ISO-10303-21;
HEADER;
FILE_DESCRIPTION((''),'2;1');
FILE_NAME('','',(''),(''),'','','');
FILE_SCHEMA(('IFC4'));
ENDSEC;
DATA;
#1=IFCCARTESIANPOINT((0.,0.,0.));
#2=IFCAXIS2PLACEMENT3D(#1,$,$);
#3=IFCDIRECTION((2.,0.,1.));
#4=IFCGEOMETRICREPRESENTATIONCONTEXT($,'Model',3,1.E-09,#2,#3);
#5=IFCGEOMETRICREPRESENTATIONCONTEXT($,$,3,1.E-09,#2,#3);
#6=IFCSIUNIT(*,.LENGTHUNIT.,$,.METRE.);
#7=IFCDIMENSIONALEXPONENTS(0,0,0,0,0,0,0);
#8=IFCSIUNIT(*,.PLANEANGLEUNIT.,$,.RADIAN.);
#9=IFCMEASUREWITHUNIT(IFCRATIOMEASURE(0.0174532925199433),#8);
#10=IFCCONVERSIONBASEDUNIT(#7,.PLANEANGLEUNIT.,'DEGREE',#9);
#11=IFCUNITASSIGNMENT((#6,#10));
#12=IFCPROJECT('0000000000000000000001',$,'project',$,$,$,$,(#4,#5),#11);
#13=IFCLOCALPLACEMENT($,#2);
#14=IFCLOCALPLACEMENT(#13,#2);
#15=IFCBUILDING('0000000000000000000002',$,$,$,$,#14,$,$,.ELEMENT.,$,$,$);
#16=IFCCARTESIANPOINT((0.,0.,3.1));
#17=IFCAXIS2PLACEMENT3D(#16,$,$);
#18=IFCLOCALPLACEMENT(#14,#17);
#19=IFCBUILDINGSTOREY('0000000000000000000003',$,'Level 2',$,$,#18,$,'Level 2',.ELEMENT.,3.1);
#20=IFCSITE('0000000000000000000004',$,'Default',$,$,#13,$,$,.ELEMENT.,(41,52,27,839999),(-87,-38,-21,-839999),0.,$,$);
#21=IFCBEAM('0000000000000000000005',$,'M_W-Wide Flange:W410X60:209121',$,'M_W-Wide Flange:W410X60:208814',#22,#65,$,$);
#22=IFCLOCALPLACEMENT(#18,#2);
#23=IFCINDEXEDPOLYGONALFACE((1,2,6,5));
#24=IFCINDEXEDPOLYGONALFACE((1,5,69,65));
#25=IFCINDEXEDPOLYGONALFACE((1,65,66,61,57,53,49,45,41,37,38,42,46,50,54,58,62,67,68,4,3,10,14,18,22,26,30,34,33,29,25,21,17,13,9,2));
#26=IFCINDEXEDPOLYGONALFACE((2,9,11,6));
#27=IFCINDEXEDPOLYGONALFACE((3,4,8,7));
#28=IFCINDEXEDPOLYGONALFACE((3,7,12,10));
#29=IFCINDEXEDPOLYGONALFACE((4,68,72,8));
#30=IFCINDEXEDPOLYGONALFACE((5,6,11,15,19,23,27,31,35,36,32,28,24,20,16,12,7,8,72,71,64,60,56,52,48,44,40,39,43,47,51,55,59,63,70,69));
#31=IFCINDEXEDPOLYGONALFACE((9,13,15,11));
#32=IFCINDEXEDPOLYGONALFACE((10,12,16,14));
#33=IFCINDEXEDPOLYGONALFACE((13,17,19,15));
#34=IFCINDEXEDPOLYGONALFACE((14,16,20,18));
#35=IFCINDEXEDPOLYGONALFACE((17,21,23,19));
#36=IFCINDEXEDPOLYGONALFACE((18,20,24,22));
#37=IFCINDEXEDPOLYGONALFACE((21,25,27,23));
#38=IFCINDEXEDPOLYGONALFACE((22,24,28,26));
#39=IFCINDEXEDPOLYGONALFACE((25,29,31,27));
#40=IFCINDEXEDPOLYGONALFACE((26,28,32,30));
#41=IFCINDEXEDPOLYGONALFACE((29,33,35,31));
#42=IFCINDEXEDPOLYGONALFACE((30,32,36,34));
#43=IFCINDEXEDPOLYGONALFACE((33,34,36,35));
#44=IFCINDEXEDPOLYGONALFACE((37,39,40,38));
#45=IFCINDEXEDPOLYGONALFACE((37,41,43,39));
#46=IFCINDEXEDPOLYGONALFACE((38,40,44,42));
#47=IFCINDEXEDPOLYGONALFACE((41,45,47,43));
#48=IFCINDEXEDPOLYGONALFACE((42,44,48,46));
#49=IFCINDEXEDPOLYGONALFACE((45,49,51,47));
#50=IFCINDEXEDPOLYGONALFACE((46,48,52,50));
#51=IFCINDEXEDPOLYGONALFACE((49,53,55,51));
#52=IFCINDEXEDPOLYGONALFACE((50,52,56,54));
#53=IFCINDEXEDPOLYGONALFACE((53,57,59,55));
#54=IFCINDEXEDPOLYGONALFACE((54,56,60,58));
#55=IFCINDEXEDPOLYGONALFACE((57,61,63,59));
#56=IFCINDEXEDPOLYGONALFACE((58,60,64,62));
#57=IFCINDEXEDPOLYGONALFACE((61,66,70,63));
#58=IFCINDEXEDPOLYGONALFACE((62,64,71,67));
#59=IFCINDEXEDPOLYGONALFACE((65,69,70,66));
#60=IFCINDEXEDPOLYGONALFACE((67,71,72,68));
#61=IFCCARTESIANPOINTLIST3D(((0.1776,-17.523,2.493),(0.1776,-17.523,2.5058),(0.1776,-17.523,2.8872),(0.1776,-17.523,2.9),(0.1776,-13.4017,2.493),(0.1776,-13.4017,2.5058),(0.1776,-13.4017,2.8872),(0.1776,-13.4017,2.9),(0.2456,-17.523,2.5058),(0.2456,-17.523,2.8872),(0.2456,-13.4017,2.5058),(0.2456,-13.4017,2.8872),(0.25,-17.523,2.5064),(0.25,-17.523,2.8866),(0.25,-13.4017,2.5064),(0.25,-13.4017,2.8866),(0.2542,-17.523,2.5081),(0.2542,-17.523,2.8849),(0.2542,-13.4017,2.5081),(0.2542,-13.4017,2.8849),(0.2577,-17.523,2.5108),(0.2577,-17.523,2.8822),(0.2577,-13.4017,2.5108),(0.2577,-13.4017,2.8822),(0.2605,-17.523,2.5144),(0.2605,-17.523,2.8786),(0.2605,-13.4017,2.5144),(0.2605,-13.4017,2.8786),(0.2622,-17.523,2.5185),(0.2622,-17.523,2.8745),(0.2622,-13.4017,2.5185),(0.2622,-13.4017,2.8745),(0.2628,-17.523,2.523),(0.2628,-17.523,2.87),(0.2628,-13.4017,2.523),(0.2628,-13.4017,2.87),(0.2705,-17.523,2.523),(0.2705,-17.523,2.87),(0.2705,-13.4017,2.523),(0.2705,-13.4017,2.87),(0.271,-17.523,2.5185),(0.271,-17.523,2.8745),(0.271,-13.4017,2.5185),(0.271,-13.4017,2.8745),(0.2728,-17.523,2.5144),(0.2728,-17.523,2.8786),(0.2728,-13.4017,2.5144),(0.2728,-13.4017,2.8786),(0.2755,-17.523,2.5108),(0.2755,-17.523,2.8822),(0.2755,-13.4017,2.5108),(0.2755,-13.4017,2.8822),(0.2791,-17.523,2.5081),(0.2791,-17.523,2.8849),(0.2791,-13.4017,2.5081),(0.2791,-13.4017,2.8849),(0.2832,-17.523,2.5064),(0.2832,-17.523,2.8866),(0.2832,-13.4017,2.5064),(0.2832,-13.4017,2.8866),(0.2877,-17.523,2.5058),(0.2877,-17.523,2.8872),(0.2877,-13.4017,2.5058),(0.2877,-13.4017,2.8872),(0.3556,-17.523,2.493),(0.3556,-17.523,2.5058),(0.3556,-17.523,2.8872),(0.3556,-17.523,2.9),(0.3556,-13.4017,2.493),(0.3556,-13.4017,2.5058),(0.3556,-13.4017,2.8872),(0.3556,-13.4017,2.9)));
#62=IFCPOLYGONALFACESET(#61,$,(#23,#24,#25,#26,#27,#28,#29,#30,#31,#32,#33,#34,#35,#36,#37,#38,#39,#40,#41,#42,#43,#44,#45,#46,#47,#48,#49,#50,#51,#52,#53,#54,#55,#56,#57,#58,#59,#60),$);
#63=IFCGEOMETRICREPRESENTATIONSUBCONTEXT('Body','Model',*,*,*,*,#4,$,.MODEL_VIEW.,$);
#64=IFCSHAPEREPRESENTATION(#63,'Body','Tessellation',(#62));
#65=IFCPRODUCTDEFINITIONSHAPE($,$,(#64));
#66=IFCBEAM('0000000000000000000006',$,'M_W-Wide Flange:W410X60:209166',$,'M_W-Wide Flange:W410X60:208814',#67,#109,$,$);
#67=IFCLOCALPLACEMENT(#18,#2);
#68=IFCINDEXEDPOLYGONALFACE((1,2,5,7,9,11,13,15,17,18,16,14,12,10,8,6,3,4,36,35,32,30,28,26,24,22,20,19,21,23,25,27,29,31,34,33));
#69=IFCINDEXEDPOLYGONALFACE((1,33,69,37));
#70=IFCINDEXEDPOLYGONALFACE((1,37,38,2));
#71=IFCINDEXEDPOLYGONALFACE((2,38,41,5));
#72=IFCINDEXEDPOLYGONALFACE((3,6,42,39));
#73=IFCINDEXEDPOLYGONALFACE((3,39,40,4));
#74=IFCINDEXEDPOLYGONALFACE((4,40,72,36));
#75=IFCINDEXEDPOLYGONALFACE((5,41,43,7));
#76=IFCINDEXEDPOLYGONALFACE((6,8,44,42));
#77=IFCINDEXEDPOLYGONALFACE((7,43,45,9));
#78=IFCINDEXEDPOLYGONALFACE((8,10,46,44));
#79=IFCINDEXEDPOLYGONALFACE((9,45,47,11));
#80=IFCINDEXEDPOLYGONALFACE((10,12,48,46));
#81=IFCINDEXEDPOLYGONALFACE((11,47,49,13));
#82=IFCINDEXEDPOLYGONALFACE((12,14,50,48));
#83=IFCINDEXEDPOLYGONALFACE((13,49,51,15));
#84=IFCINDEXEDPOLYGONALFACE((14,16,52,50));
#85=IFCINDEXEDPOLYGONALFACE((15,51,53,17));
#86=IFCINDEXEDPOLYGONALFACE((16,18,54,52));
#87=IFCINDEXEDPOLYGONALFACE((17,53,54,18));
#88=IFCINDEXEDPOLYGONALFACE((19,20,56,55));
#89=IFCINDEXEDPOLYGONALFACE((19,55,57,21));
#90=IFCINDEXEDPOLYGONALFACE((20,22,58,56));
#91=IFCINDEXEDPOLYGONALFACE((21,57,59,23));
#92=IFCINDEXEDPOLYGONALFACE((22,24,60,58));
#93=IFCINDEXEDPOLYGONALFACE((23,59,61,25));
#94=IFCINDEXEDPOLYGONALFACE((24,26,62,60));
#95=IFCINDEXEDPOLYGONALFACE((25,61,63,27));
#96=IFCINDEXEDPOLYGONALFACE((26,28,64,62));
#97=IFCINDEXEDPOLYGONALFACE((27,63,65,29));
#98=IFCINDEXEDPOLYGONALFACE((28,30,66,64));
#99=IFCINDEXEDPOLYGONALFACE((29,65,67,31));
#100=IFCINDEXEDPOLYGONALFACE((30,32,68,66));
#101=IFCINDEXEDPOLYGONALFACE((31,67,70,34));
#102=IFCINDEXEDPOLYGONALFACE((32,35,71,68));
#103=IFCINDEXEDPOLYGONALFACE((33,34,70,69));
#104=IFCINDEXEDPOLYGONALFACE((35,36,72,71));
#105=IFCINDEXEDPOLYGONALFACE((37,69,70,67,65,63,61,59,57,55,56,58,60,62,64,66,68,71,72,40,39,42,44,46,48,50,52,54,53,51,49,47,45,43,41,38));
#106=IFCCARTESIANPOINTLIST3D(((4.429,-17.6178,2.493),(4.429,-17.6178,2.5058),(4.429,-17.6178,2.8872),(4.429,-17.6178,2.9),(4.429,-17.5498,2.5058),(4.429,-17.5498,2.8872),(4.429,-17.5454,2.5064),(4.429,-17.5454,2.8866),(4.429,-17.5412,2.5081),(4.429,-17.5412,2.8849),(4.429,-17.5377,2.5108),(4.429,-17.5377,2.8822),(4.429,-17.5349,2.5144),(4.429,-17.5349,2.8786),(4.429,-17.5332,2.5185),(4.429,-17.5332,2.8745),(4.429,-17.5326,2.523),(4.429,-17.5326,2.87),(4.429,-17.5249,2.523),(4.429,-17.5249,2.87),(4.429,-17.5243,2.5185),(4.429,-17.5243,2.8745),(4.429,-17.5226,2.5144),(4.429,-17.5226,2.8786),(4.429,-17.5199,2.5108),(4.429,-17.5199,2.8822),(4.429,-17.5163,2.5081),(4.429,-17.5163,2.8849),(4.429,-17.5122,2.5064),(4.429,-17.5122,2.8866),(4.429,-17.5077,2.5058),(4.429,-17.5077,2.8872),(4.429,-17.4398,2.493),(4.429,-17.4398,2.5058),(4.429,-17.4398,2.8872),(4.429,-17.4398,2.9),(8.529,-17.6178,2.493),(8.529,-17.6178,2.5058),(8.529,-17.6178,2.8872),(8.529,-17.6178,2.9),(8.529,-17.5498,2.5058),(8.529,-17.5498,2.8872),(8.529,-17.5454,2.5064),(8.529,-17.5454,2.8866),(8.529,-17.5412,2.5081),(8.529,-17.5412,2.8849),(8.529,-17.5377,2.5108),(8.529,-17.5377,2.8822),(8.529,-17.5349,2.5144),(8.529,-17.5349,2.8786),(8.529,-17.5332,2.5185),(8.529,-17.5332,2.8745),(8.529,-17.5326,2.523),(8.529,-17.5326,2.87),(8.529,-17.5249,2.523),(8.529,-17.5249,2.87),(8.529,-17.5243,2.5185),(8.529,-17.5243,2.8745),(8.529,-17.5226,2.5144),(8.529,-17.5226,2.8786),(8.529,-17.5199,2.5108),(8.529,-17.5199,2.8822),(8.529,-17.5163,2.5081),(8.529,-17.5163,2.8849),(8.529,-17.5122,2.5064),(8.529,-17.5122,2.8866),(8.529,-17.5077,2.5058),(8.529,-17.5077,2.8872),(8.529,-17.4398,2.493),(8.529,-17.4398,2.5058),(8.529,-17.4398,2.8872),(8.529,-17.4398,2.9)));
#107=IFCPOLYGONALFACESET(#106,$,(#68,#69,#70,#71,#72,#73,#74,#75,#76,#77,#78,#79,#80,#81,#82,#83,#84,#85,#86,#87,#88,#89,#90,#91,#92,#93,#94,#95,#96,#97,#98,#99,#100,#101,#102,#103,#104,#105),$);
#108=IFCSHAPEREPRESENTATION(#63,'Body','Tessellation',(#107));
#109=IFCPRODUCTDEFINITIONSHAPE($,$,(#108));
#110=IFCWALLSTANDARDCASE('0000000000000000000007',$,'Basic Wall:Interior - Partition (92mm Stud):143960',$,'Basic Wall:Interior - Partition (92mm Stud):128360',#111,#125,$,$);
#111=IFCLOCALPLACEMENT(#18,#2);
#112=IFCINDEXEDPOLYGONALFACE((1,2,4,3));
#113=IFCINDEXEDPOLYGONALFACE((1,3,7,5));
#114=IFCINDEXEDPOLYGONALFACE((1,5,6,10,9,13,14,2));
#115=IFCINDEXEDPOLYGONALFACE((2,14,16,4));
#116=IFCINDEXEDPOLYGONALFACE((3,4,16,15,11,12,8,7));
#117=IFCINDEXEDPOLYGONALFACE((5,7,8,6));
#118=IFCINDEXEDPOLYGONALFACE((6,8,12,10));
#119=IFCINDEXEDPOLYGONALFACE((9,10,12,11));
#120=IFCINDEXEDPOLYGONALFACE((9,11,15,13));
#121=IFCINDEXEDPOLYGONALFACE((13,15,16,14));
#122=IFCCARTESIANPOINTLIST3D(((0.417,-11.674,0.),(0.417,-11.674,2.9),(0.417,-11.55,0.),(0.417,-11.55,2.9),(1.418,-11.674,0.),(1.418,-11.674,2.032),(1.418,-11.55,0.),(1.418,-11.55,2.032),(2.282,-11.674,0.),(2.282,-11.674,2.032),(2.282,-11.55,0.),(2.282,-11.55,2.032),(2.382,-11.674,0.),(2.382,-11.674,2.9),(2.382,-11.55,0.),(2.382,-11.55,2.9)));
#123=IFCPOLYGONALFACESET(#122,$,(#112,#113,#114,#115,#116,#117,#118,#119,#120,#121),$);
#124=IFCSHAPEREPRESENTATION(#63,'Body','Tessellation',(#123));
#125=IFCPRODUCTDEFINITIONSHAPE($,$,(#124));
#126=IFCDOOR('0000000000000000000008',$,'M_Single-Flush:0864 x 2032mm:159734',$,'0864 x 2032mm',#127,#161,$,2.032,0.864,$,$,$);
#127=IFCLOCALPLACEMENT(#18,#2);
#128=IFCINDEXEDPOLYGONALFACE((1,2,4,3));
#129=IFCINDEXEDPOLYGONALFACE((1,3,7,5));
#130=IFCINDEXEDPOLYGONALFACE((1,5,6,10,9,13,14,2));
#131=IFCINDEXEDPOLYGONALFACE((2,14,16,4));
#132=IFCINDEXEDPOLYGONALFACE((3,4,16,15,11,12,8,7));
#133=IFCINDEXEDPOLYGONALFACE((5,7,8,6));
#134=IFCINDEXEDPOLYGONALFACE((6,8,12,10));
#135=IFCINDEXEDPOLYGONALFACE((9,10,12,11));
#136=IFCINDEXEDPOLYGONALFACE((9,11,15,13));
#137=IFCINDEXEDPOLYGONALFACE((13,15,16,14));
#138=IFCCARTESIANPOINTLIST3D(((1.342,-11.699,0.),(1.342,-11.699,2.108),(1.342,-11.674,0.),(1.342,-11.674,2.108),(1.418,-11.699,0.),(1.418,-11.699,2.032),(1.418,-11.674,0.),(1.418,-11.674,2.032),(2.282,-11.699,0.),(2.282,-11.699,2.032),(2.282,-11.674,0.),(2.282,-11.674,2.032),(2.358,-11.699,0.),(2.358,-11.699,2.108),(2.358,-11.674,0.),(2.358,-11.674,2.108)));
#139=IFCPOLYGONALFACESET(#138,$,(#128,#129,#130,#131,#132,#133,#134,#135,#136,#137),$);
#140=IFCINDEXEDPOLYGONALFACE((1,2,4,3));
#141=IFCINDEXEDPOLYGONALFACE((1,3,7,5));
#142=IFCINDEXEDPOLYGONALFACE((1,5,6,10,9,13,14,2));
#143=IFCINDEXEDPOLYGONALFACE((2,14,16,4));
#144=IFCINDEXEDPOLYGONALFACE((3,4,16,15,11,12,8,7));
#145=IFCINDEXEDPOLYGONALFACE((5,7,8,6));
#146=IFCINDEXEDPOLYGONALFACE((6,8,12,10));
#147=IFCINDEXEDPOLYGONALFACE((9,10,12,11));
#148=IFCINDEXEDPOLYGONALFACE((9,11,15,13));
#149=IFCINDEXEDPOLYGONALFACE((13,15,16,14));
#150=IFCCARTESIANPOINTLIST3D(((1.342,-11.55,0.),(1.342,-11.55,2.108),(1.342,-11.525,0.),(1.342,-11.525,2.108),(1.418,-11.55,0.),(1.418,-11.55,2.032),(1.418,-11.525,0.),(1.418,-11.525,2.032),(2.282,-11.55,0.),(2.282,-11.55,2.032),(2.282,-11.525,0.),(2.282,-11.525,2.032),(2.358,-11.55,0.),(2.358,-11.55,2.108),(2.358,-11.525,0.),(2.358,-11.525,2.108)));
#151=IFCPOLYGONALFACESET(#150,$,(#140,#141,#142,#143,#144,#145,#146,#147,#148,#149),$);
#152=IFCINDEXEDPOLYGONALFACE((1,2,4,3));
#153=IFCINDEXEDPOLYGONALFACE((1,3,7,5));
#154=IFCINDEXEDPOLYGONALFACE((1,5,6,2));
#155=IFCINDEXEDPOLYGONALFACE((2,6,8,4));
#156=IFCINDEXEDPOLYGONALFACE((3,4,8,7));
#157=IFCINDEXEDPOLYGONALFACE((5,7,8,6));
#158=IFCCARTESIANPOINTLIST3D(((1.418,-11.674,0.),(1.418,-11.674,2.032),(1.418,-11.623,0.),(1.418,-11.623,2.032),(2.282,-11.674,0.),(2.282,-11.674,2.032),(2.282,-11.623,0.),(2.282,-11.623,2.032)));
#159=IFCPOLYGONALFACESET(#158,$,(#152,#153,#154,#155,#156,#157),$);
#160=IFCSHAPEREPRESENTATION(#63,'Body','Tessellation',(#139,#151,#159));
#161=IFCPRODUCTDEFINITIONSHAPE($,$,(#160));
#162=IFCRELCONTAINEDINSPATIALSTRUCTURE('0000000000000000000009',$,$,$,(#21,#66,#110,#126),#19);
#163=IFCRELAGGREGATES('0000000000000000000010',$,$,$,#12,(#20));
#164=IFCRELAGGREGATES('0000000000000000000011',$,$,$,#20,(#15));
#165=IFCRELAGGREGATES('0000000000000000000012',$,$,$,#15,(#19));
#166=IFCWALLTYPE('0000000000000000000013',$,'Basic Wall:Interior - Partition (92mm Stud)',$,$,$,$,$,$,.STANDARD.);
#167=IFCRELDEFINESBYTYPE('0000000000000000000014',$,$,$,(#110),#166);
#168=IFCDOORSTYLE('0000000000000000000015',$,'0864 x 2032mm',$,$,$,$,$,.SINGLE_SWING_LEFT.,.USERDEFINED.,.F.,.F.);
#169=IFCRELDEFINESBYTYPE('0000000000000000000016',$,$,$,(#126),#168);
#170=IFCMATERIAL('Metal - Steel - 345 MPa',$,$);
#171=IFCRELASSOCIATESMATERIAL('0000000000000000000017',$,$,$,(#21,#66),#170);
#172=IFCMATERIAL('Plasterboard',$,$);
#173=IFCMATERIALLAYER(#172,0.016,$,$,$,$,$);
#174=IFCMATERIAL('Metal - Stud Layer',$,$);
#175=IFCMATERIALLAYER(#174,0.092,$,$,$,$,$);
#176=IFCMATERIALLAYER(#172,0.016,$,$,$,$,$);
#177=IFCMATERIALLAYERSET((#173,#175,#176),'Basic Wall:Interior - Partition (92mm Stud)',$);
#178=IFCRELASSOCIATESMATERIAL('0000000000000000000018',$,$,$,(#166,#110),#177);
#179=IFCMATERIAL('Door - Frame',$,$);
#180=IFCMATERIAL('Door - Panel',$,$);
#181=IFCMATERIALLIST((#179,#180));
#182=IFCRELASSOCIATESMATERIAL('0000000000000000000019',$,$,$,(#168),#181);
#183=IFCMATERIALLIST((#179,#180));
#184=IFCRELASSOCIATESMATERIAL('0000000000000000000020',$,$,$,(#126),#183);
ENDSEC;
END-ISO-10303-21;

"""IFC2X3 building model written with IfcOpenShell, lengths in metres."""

from ifc_helpers import new_model, entity, si_unit, converted_unit, direction, frame, frame_2d, origin, place, context, subcontext, project, spatial, polyline, rectangle, i_section, outline, extrude, source, transform, mapped, material, material_list, layer, layer_set, layer_usage, type_object, type_shapes, element, fill, save


model = new_model("IFC2X3")

# Units and contexts
model_context = context("Model", 3, precision=1e-09, world=origin(), true_north=direction((2.0, 0.0, 1.0)))
context_of_model = context(None, 3, precision=1e-09, world=origin(), true_north=direction((2.0, 0.0, 1.0)))
body_context = subcontext(model_context, "Body", "Model", "MODEL_VIEW")
ifc_project = project(units=[si_unit("LENGTHUNIT", "METRE"), converted_unit("PLANEANGLEUNIT", "DEGREE", entity("IfcRatioMeasure", 0.0174532925199433), si_unit("PLANEANGLEUNIT", "RADIAN"), dimensions=[0, 0, 0, 0, 0, 0, 0])], contexts=[model_context, context_of_model])

# Site, building, storey
site_placement = place(None, origin())
site = spatial("IfcSite", under=ifc_project, at=site_placement, Name="Default", CompositionType="ELEMENT", RefLatitude=(41, 52, 27, 839999), RefLongitude=(-87, -38, -21, -839999), RefElevation=0.0)
building_placement = place(site_placement, origin())
building = spatial("IfcBuilding", under=site, at=building_placement, CompositionType="ELEMENT")
storey_placement = place(building_placement, frame((0.0, 0.0, 3.1)))
storey = spatial("IfcBuildingStorey", under=building, at=storey_placement, Name="Level 2", LongName="Level 2", CompositionType="ELEMENT", Elevation=3.1)

# Beams
ifc_material_1 = material(Name="Metal - Steel - 345 MPa")
beam_1_placement = place(storey_placement, frame((0.2666, -13.4017, 2.9), z_axis=(0.0, 0.0, 1.0), x_axis=(0.0, -1.0, 0.0)))
element("IfcBeam", 1, at=beam_1_placement, inside=storey, material=ifc_material_1, Name="M_W-Wide Flange:W410X60:209121", ObjectType="M_W-Wide Flange:W410X60:208814", context=body_context, shape_type="SweptSolid", body=[
    extrude(i_section(OverallWidth=0.178, OverallDepth=0.407, WebThickness=0.0077, FlangeThickness=0.0128, FilletRadius=0.0172, at=frame_2d((0.0, 0.0), x_axis=(0.0, 1.0))), frame((0.0, 0.0, -0.2035), z_axis=(1.0, 0.0, 0.0), x_axis=(0.0, 0.0, -1.0)), (0.0, 0.0, 1.0), 4.1213),
])
beam_2_placement = place(storey_placement, frame((4.429, -17.5288, 2.9)))
element("IfcBeam", 2, at=beam_2_placement, inside=storey, material=ifc_material_1, Name="M_W-Wide Flange:W410X60:209166", ObjectType="M_W-Wide Flange:W410X60:208814", context=body_context, shape_type="SweptSolid", body=[
    extrude(i_section(OverallWidth=0.178, OverallDepth=0.407, WebThickness=0.0077, FlangeThickness=0.0128, FilletRadius=0.0172, at=frame_2d((0.0, 0.0), x_axis=(0.0, 1.0))), frame((0.0, 0.0, -0.2035), z_axis=(1.0, 0.0, 0.0), x_axis=(0.0, 0.0, -1.0)), (0.0, 0.0, 1.0), 4.1),
])

# Shared definitions
ifc_material_2 = material(Name="Metal - Stud Layer")
ifc_material_3 = material(Name="Plasterboard")

# Wall, opening, door
ifc_layer_1 = layer(ifc_material_3, 0.016)
ifc_layer_2 = layer(ifc_material_2, 0.092)
ifc_layer_3 = layer(ifc_material_3, 0.016)
ifc_layer_set_1 = layer_set([ifc_layer_1, ifc_layer_2, ifc_layer_3], Name="Basic Wall:Interior - Partition (92mm Stud)")
ifc_layer_usage_1 = layer_usage(ifc_layer_set_1, "AXIS2", "NEGATIVE", 0.062)
wall_type_1 = type_object("IfcWallType", Name="Basic Wall:Interior - Partition (92mm Stud)", PredefinedType="STANDARD", material=ifc_layer_set_1)
wall_1_placement = place(storey_placement, frame((2.382, -11.612, 0.0), z_axis=(0.0, 0.0, 1.0), x_axis=(-1.0, 0.0, 0.0)))
wall_1 = element("IfcWallStandardCase", 3, at=wall_1_placement, inside=storey, type_object=wall_type_1, material=ifc_layer_usage_1, Name="Basic Wall:Interior - Partition (92mm Stud):143960", ObjectType="Basic Wall:Interior - Partition (92mm Stud):128360", context=body_context, shape_type="SweptSolid", body=[
    extrude(rectangle(XDim=1.965, YDim=0.124, at=frame_2d((0.9825, 0.0), x_axis=(-1.0, 0.0))), origin(), (0.0, 0.0, 1.0), 2.9),
])
opening_1_placement = place(wall_1_placement, frame((0.1, -0.062, 0.0)))
opening_1 = element("IfcOpeningElement", 4, at=opening_1_placement, cuts=wall_1, ObjectType="Opening", context=body_context, shape_type="SweptSolid", body=[
    extrude(rectangle(XDim=0.864, YDim=2.032, at=frame_2d((1.016, 0.432), x_axis=(0.0, -1.0))), frame((0.0, 0.0, 0.0), z_axis=(0.0, 1.0, 0.0), x_axis=(0.0, 0.0, 1.0)), (0.0, 0.0, 1.0), 0.124),
])
ifc_material_4 = material(Name="Door - Frame")
ifc_material_5 = material(Name="Door - Panel")
ifc_material_list_1 = material_list([ifc_material_4, ifc_material_5])
ifc_material_list_2 = material_list([ifc_material_4, ifc_material_5])
door_style_1 = type_object("IfcDoorStyle", Name="0864 x 2032mm", ConstructionType="USERDEFINED", OperationType="SINGLE_SWING_LEFT", ParameterTakesPrecedence=False, Sizeable=False, material=ifc_material_list_2)
shared_shape_1 = source(origin(), body_context, "Body", "SweptSolid", [
    extrude(outline(polyline([(-0.508, -1.073), (0.508, -1.073), (0.508, 1.035), (0.432, 1.035), (0.432, -0.997), (-0.432, -0.997), (-0.432, 1.035), (-0.508, 1.035), (-0.508, -1.073)])), frame((0.432, 0.149, 1.035), z_axis=(0.0, -1.0, 0.0), x_axis=(-1.0, 0.0, 0.0)), (0.0, 0.0, 1.0), 0.025),
    extrude(outline(polyline([(-1.073, -0.508), (1.035, -0.508), (1.035, -0.432), (-0.997, -0.432), (-0.997, 0.432), (1.035, 0.432), (1.035, 0.508), (-1.073, 0.508), (-1.073, -0.508)])), frame((0.432, 0.0, 1.035), z_axis=(0.0, -1.0, 0.0), x_axis=(0.0, 0.0, -1.0)), (0.0, 0.0, 1.0), 0.025),
    extrude(rectangle(XDim=0.864, YDim=0.051, at=frame_2d((0.0, 0.0), x_axis=(1.0, 0.0))), frame((0.432, 0.0985, 0.0)), (0.0, 0.0, 1.0), 2.032),
])
type_shapes(door_style_1, [shared_shape_1])
door_1_placement = place(opening_1_placement, origin())
door_1 = element("IfcDoor", 5, at=door_1_placement, inside=storey, type_object=door_style_1, material=ifc_material_list_1, Name="M_Single-Flush:0864 x 2032mm:159734", ObjectType="0864 x 2032mm", OverallHeight=2.032, OverallWidth=0.864, context=body_context, shape_type="MappedRepresentation", body=[
    mapped(shared_shape_1, transform((0.0, 0.0, 0.0), scale=1.0)),
])
fill(opening_1, door_1)

save(model, "model.ifc")
